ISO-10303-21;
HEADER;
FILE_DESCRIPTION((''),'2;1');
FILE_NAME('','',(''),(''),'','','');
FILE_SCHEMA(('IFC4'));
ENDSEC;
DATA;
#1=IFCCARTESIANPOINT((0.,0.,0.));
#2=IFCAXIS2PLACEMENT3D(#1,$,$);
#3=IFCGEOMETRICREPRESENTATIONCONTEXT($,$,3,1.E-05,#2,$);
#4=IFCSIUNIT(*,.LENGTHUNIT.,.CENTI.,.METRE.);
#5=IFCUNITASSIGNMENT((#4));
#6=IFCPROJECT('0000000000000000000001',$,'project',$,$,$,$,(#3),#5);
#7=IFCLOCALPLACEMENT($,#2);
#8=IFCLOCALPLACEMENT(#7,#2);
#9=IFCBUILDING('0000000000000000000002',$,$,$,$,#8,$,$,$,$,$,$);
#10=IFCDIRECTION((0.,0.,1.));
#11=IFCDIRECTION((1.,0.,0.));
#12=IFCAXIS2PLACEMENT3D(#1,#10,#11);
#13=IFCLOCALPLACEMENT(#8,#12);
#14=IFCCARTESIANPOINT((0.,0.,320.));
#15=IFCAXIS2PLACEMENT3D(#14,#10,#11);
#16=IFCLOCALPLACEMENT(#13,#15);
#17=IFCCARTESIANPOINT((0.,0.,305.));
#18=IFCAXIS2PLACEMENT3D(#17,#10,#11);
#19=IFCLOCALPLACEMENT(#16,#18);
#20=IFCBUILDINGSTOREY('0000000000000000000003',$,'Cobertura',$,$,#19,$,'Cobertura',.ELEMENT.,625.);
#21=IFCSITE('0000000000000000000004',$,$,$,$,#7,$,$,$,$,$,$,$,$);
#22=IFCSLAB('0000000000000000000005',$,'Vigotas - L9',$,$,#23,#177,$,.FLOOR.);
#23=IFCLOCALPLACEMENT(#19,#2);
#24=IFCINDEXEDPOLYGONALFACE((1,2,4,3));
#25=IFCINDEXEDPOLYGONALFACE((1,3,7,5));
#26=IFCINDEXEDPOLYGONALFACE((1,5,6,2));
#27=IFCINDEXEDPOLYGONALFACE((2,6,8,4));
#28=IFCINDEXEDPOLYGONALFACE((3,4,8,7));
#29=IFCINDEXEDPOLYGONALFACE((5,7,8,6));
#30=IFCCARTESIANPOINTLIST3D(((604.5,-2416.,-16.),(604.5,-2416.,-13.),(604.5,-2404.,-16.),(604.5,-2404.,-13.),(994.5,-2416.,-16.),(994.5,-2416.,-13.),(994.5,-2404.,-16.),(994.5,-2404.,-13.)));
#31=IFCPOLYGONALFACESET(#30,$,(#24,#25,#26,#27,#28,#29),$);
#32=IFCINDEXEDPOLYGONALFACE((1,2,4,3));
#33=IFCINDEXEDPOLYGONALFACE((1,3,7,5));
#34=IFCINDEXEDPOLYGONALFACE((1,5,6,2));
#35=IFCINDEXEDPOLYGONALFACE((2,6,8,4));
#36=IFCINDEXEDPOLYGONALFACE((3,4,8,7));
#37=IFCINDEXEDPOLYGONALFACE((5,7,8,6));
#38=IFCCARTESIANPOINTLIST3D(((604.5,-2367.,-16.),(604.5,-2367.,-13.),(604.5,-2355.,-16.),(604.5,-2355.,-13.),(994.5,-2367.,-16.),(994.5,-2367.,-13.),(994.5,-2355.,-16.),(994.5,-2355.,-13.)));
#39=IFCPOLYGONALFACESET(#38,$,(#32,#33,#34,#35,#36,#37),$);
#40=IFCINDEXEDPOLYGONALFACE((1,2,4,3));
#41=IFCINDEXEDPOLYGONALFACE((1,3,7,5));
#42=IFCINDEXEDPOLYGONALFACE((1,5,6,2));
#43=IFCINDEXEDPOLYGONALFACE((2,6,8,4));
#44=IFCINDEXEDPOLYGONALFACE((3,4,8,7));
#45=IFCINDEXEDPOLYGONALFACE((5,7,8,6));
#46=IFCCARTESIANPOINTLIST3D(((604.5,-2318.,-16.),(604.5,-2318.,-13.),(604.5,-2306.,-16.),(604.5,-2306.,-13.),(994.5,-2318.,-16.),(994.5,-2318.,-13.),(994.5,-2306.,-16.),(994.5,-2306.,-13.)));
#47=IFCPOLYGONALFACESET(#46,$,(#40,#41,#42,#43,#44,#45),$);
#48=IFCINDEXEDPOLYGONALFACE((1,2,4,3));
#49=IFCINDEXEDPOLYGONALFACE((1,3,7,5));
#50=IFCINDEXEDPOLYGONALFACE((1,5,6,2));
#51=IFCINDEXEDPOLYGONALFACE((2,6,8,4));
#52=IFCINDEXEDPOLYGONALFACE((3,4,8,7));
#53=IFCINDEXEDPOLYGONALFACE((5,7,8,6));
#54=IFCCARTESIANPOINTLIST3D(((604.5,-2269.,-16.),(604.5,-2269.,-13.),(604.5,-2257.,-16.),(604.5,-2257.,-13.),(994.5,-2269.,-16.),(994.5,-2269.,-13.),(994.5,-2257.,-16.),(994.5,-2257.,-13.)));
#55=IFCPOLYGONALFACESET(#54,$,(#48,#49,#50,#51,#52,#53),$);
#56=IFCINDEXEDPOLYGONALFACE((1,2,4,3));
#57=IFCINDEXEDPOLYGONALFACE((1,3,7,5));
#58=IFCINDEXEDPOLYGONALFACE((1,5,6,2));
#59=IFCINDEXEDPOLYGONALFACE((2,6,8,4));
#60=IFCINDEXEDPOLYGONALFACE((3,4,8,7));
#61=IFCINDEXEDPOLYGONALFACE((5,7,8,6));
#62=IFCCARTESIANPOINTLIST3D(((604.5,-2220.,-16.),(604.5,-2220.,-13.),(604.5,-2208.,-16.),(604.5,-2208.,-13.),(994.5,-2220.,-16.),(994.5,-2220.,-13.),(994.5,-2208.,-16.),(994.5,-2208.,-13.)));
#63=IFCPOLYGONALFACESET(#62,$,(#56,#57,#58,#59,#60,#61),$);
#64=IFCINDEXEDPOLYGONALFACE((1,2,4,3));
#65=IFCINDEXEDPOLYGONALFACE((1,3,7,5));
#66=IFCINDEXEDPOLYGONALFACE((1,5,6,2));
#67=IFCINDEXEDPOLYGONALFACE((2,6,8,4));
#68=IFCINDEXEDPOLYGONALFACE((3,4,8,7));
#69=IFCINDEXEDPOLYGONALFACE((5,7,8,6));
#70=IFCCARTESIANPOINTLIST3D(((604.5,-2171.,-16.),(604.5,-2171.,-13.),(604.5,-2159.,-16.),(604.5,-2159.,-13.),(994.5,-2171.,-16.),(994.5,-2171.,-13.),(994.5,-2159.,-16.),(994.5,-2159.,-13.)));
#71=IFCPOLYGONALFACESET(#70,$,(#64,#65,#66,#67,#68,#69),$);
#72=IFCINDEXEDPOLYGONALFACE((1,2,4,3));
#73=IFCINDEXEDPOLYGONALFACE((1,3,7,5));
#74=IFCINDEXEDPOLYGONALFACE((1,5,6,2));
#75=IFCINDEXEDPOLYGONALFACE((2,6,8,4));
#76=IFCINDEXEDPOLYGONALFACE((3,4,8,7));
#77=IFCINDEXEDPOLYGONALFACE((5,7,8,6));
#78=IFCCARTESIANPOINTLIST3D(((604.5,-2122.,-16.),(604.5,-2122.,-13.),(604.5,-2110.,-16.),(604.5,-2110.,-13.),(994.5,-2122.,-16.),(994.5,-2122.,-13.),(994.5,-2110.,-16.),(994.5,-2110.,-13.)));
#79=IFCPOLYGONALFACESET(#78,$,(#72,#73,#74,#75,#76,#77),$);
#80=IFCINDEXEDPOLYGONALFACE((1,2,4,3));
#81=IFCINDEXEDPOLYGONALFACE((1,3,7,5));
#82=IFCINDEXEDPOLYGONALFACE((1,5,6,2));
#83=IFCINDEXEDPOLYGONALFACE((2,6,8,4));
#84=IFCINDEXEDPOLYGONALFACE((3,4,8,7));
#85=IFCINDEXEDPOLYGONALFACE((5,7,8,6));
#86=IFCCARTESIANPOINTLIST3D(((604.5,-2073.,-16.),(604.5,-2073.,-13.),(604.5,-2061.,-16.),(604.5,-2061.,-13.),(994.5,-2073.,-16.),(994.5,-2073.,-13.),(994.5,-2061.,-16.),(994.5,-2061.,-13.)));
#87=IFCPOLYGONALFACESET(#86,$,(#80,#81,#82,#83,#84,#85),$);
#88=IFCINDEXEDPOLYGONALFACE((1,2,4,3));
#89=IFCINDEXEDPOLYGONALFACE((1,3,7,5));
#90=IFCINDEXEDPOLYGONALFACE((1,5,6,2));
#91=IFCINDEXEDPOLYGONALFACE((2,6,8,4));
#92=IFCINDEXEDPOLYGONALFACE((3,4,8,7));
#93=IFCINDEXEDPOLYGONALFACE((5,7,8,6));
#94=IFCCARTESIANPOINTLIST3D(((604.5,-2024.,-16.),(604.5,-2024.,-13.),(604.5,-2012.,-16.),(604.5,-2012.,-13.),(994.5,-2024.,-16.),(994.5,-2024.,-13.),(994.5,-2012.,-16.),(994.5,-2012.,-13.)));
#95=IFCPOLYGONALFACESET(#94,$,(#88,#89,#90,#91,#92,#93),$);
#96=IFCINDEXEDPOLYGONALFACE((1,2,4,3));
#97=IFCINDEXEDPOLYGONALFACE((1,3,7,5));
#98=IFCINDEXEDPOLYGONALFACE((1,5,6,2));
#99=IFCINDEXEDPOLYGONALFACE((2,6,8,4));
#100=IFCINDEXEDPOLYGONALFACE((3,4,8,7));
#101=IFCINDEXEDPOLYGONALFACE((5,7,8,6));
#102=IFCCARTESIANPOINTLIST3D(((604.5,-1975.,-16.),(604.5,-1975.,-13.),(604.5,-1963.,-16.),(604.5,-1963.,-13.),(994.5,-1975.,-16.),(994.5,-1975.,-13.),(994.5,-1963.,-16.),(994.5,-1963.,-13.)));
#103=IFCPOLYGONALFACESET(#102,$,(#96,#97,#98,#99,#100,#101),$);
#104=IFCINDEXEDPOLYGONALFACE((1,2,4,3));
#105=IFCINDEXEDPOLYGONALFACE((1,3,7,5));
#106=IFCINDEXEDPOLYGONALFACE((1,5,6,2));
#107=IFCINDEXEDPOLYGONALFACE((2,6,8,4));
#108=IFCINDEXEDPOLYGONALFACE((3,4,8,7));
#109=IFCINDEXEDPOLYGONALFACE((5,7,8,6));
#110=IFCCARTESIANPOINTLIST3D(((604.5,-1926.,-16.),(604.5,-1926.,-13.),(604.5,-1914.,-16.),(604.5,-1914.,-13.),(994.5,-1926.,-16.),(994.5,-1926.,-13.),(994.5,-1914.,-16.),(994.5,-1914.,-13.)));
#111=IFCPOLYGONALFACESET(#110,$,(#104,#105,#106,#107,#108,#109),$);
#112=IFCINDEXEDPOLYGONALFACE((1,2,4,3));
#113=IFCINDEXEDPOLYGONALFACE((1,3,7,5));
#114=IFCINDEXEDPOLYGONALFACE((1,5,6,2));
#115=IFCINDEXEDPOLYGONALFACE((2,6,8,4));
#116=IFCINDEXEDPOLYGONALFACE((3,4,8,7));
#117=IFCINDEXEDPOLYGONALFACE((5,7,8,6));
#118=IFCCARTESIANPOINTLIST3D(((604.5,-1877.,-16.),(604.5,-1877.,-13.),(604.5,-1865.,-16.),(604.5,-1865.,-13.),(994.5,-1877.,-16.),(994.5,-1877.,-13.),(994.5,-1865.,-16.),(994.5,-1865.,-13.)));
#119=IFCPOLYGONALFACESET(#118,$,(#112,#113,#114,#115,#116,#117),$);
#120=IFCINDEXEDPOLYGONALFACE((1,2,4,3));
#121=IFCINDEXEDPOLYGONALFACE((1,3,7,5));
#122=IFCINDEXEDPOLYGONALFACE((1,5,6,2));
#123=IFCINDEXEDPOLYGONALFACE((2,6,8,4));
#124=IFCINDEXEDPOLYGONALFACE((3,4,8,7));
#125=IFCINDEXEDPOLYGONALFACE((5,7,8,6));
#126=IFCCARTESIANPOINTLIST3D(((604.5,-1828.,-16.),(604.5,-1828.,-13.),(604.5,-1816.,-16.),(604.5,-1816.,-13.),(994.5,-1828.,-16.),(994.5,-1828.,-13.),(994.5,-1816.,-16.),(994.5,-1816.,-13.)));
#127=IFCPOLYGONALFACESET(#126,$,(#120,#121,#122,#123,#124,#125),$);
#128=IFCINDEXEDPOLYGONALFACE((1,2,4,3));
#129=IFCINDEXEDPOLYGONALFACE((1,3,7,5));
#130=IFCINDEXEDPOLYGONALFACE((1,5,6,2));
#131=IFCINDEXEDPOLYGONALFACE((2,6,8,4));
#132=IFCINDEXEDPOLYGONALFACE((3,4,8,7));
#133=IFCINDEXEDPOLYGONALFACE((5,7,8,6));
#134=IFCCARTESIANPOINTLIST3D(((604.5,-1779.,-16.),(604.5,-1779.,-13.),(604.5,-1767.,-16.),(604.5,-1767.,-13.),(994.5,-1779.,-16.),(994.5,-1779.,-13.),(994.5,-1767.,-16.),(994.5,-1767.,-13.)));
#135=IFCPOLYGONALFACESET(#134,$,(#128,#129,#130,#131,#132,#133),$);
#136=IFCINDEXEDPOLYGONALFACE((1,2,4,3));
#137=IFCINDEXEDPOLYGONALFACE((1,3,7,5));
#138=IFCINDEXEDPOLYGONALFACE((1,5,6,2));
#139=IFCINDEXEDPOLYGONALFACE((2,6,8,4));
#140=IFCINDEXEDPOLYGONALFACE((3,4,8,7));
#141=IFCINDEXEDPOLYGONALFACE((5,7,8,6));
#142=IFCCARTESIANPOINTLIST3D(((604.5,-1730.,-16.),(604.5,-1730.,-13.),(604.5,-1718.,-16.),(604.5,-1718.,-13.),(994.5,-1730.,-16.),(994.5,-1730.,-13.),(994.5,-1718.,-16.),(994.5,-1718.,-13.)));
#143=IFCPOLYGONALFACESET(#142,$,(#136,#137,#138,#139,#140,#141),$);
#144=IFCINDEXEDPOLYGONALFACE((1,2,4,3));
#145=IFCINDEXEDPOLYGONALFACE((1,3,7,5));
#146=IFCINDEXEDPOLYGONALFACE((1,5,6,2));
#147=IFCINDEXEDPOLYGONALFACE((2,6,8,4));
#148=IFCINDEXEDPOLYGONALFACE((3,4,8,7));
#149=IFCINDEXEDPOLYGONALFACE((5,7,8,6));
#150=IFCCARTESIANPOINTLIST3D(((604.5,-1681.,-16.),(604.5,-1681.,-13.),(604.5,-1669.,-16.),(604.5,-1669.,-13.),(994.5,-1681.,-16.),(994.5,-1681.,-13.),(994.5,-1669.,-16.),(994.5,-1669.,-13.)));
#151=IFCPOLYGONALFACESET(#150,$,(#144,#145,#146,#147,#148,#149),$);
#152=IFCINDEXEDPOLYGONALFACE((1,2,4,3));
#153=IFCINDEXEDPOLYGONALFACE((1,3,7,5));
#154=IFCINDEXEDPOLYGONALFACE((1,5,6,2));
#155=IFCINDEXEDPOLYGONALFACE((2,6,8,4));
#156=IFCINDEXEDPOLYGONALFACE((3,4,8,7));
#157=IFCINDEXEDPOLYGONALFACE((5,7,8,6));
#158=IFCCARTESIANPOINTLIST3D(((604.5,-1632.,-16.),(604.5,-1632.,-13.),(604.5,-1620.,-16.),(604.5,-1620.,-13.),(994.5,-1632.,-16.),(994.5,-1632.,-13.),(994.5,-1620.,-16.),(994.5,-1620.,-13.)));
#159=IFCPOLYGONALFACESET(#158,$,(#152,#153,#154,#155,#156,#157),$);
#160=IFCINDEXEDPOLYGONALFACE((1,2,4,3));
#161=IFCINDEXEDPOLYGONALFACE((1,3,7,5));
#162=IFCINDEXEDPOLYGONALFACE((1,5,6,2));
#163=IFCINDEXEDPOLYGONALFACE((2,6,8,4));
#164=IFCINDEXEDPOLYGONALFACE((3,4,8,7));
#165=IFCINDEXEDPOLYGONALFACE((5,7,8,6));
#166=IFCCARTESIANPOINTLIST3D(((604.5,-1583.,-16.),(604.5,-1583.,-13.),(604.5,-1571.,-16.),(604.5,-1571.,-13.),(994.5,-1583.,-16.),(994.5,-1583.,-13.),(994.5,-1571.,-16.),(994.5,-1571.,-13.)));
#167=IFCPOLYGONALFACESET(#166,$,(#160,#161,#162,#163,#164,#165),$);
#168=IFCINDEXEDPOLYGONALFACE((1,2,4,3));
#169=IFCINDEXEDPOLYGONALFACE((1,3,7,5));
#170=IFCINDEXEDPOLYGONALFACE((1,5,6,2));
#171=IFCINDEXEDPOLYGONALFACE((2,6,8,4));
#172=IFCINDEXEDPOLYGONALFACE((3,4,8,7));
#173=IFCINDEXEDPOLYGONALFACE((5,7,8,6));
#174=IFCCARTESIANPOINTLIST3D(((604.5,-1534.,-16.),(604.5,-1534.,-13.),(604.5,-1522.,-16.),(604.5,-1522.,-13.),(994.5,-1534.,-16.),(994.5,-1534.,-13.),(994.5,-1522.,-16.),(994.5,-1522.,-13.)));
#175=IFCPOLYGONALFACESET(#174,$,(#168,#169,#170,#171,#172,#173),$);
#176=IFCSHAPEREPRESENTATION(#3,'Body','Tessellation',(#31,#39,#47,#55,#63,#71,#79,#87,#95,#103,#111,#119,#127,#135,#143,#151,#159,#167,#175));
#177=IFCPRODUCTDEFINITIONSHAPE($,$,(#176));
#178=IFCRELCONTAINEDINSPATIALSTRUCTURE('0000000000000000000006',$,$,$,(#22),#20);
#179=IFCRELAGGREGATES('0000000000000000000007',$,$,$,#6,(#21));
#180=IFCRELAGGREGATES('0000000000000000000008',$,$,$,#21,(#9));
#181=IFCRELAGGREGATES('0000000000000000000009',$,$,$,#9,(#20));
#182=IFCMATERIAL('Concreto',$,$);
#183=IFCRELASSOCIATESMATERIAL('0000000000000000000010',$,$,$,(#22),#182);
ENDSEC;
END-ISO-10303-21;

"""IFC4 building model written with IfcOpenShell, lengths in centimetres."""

from ifc_helpers import new_model, si_unit, frame, origin, origin_with_axes, place, context, project, spatial, polyline, outline, extrude, material, element, save


model = new_model("IFC4")

# Units and contexts
context_of_model = context(None, 3, precision=1e-05, world=origin())
ifc_project = project(units=[si_unit("LENGTHUNIT", "METRE", prefix="CENTI")], contexts=[context_of_model])

# Site, building, storey
site_placement = place(None, origin())
site = spatial("IfcSite", under=ifc_project, at=site_placement)
building_placement = place(site_placement, origin())
building = spatial("IfcBuilding", under=site, at=building_placement)
placement_1 = place(building_placement, origin_with_axes())
placement_2 = place(placement_1, frame((0.0, 0.0, 320.0), z_axis=(0.0, 0.0, 1.0), x_axis=(1.0, 0.0, 0.0)))
storey_placement = place(placement_2, frame((0.0, 0.0, 305.0), z_axis=(0.0, 0.0, 1.0), x_axis=(1.0, 0.0, 0.0)))
storey = spatial("IfcBuildingStorey", under=building, at=storey_placement, Name="Cobertura", LongName="Cobertura", CompositionType="ELEMENT", Elevation=625.0)

# Shared definitions
ifc_material_1 = material(Name="Concreto")

# Slab
slab_1_placement = place(storey_placement, frame((799.5, -1969.0, -13.0), z_axis=(0.0, 0.0, 1.0), x_axis=(1.0, 0.0, 0.0)))
element("IfcSlab", 1, at=slab_1_placement, inside=storey, material=ifc_material_1, Name="Vigotas - L9", PredefinedType="FLOOR", context=context_of_model, shape_type="SolidModel", body=[
    extrude(outline(polyline([(6.0, 1.5), (-6.0, 1.5), (-6.0, -1.5), (6.0, -1.5), (6.0, 1.5), (6.0, 1.5)])), frame((-195.0, -441.0, -1.5), z_axis=(1.0, 0.0, 0.0), x_axis=(0.0, -1.0, 0.0)), (0.0, 0.0, 1.0), 390.0),
    extrude(outline(polyline([(6.0, 1.5), (-6.0, 1.5), (-6.0, -1.5), (6.0, -1.5), (6.0, 1.5), (6.0, 1.5)])), frame((-195.0, -392.0, -1.5), z_axis=(1.0, 0.0, 0.0), x_axis=(0.0, -1.0, 0.0)), (0.0, 0.0, 1.0), 390.0),
    extrude(outline(polyline([(6.0, 1.5), (-6.0, 1.5), (-6.0, -1.5), (6.0, -1.5), (6.0, 1.5), (6.0, 1.5)])), frame((-195.0, -343.0, -1.5), z_axis=(1.0, 0.0, 0.0), x_axis=(0.0, -1.0, 0.0)), (0.0, 0.0, 1.0), 390.0),
    extrude(outline(polyline([(6.0, 1.5), (-6.0, 1.5), (-6.0, -1.5), (6.0, -1.5), (6.0, 1.5), (6.0, 1.5)])), frame((-195.0, -294.0, -1.5), z_axis=(1.0, 0.0, 0.0), x_axis=(0.0, -1.0, 0.0)), (0.0, 0.0, 1.0), 390.0),
    extrude(outline(polyline([(6.0, 1.5), (-6.0, 1.5), (-6.0, -1.5), (6.0, -1.5), (6.0, 1.5), (6.0, 1.5)])), frame((-195.0, -245.0, -1.5), z_axis=(1.0, 0.0, 0.0), x_axis=(0.0, -1.0, 0.0)), (0.0, 0.0, 1.0), 390.0),
    extrude(outline(polyline([(6.0, 1.5), (-6.0, 1.5), (-6.0, -1.5), (6.0, -1.5), (6.0, 1.5), (6.0, 1.5)])), frame((-195.0, -196.0, -1.5), z_axis=(1.0, 0.0, 0.0), x_axis=(0.0, -1.0, 0.0)), (0.0, 0.0, 1.0), 390.0),
    extrude(outline(polyline([(6.0, 1.5), (-6.0, 1.5), (-6.0, -1.5), (6.0, -1.5), (6.0, 1.5), (6.0, 1.5)])), frame((-195.0, -147.0, -1.5), z_axis=(1.0, 0.0, 0.0), x_axis=(0.0, -1.0, 0.0)), (0.0, 0.0, 1.0), 390.0),
    extrude(outline(polyline([(6.0, 1.5), (-6.0, 1.5), (-6.0, -1.5), (6.0, -1.5), (6.0, 1.5), (6.0, 1.5)])), frame((-195.0, -98.0, -1.5), z_axis=(1.0, 0.0, 0.0), x_axis=(0.0, -1.0, 0.0)), (0.0, 0.0, 1.0), 390.0),
    extrude(outline(polyline([(6.0, 1.5), (-6.0, 1.5), (-6.0, -1.5), (6.0, -1.5), (6.0, 1.5), (6.0, 1.5)])), frame((-195.0, -49.0, -1.5), z_axis=(1.0, 0.0, 0.0), x_axis=(0.0, -1.0, 0.0)), (0.0, 0.0, 1.0), 390.0),
    extrude(outline(polyline([(6.0, 1.5), (-6.0, 1.5), (-6.0, -1.5), (6.0, -1.5), (6.0, 1.5), (6.0, 1.5)])), frame((-195.0, 0.0, -1.5), z_axis=(1.0, 0.0, 0.0), x_axis=(0.0, -1.0, 0.0)), (0.0, 0.0, 1.0), 390.0),
    extrude(outline(polyline([(6.0, 1.5), (-6.0, 1.5), (-6.0, -1.5), (6.0, -1.5), (6.0, 1.5), (6.0, 1.5)])), frame((-195.0, 49.0, -1.5), z_axis=(1.0, 0.0, 0.0), x_axis=(0.0, -1.0, 0.0)), (0.0, 0.0, 1.0), 390.0),
    extrude(outline(polyline([(6.0, 1.5), (-6.0, 1.5), (-6.0, -1.5), (6.0, -1.5), (6.0, 1.5), (6.0, 1.5)])), frame((-195.0, 98.0, -1.5), z_axis=(1.0, 0.0, 0.0), x_axis=(0.0, -1.0, 0.0)), (0.0, 0.0, 1.0), 390.0),
    extrude(outline(polyline([(6.0, 1.5), (-6.0, 1.5), (-6.0, -1.5), (6.0, -1.5), (6.0, 1.5), (6.0, 1.5)])), frame((-195.0, 147.0, -1.5), z_axis=(1.0, 0.0, 0.0), x_axis=(0.0, -1.0, 0.0)), (0.0, 0.0, 1.0), 390.0),
    extrude(outline(polyline([(6.0, 1.5), (-6.0, 1.5), (-6.0, -1.5), (6.0, -1.5), (6.0, 1.5), (6.0, 1.5)])), frame((-195.0, 196.0, -1.5), z_axis=(1.0, 0.0, 0.0), x_axis=(0.0, -1.0, 0.0)), (0.0, 0.0, 1.0), 390.0),
    extrude(outline(polyline([(6.0, 1.5), (-6.0, 1.5), (-6.0, -1.5), (6.0, -1.5), (6.0, 1.5), (6.0, 1.5)])), frame((-195.0, 245.0, -1.5), z_axis=(1.0, 0.0, 0.0), x_axis=(0.0, -1.0, 0.0)), (0.0, 0.0, 1.0), 390.0),
    extrude(outline(polyline([(6.0, 1.5), (-6.0, 1.5), (-6.0, -1.5), (6.0, -1.5), (6.0, 1.5), (6.0, 1.5)])), frame((-195.0, 294.0, -1.5), z_axis=(1.0, 0.0, 0.0), x_axis=(0.0, -1.0, 0.0)), (0.0, 0.0, 1.0), 390.0),
    extrude(outline(polyline([(6.0, 1.5), (-6.0, 1.5), (-6.0, -1.5), (6.0, -1.5), (6.0, 1.5), (6.0, 1.5)])), frame((-195.0, 343.0, -1.5), z_axis=(1.0, 0.0, 0.0), x_axis=(0.0, -1.0, 0.0)), (0.0, 0.0, 1.0), 390.0),
    extrude(outline(polyline([(6.0, 1.5), (-6.0, 1.5), (-6.0, -1.5), (6.0, -1.5), (6.0, 1.5), (6.0, 1.5)])), frame((-195.0, 392.0, -1.5), z_axis=(1.0, 0.0, 0.0), x_axis=(0.0, -1.0, 0.0)), (0.0, 0.0, 1.0), 390.0),
    extrude(outline(polyline([(6.0, 1.5), (-6.0, 1.5), (-6.0, -1.5), (6.0, -1.5), (6.0, 1.5), (6.0, 1.5)])), frame((-195.0, 441.0, -1.5), z_axis=(1.0, 0.0, 0.0), x_axis=(0.0, -1.0, 0.0)), (0.0, 0.0, 1.0), 390.0),
])

save(model, "model.ifc")
